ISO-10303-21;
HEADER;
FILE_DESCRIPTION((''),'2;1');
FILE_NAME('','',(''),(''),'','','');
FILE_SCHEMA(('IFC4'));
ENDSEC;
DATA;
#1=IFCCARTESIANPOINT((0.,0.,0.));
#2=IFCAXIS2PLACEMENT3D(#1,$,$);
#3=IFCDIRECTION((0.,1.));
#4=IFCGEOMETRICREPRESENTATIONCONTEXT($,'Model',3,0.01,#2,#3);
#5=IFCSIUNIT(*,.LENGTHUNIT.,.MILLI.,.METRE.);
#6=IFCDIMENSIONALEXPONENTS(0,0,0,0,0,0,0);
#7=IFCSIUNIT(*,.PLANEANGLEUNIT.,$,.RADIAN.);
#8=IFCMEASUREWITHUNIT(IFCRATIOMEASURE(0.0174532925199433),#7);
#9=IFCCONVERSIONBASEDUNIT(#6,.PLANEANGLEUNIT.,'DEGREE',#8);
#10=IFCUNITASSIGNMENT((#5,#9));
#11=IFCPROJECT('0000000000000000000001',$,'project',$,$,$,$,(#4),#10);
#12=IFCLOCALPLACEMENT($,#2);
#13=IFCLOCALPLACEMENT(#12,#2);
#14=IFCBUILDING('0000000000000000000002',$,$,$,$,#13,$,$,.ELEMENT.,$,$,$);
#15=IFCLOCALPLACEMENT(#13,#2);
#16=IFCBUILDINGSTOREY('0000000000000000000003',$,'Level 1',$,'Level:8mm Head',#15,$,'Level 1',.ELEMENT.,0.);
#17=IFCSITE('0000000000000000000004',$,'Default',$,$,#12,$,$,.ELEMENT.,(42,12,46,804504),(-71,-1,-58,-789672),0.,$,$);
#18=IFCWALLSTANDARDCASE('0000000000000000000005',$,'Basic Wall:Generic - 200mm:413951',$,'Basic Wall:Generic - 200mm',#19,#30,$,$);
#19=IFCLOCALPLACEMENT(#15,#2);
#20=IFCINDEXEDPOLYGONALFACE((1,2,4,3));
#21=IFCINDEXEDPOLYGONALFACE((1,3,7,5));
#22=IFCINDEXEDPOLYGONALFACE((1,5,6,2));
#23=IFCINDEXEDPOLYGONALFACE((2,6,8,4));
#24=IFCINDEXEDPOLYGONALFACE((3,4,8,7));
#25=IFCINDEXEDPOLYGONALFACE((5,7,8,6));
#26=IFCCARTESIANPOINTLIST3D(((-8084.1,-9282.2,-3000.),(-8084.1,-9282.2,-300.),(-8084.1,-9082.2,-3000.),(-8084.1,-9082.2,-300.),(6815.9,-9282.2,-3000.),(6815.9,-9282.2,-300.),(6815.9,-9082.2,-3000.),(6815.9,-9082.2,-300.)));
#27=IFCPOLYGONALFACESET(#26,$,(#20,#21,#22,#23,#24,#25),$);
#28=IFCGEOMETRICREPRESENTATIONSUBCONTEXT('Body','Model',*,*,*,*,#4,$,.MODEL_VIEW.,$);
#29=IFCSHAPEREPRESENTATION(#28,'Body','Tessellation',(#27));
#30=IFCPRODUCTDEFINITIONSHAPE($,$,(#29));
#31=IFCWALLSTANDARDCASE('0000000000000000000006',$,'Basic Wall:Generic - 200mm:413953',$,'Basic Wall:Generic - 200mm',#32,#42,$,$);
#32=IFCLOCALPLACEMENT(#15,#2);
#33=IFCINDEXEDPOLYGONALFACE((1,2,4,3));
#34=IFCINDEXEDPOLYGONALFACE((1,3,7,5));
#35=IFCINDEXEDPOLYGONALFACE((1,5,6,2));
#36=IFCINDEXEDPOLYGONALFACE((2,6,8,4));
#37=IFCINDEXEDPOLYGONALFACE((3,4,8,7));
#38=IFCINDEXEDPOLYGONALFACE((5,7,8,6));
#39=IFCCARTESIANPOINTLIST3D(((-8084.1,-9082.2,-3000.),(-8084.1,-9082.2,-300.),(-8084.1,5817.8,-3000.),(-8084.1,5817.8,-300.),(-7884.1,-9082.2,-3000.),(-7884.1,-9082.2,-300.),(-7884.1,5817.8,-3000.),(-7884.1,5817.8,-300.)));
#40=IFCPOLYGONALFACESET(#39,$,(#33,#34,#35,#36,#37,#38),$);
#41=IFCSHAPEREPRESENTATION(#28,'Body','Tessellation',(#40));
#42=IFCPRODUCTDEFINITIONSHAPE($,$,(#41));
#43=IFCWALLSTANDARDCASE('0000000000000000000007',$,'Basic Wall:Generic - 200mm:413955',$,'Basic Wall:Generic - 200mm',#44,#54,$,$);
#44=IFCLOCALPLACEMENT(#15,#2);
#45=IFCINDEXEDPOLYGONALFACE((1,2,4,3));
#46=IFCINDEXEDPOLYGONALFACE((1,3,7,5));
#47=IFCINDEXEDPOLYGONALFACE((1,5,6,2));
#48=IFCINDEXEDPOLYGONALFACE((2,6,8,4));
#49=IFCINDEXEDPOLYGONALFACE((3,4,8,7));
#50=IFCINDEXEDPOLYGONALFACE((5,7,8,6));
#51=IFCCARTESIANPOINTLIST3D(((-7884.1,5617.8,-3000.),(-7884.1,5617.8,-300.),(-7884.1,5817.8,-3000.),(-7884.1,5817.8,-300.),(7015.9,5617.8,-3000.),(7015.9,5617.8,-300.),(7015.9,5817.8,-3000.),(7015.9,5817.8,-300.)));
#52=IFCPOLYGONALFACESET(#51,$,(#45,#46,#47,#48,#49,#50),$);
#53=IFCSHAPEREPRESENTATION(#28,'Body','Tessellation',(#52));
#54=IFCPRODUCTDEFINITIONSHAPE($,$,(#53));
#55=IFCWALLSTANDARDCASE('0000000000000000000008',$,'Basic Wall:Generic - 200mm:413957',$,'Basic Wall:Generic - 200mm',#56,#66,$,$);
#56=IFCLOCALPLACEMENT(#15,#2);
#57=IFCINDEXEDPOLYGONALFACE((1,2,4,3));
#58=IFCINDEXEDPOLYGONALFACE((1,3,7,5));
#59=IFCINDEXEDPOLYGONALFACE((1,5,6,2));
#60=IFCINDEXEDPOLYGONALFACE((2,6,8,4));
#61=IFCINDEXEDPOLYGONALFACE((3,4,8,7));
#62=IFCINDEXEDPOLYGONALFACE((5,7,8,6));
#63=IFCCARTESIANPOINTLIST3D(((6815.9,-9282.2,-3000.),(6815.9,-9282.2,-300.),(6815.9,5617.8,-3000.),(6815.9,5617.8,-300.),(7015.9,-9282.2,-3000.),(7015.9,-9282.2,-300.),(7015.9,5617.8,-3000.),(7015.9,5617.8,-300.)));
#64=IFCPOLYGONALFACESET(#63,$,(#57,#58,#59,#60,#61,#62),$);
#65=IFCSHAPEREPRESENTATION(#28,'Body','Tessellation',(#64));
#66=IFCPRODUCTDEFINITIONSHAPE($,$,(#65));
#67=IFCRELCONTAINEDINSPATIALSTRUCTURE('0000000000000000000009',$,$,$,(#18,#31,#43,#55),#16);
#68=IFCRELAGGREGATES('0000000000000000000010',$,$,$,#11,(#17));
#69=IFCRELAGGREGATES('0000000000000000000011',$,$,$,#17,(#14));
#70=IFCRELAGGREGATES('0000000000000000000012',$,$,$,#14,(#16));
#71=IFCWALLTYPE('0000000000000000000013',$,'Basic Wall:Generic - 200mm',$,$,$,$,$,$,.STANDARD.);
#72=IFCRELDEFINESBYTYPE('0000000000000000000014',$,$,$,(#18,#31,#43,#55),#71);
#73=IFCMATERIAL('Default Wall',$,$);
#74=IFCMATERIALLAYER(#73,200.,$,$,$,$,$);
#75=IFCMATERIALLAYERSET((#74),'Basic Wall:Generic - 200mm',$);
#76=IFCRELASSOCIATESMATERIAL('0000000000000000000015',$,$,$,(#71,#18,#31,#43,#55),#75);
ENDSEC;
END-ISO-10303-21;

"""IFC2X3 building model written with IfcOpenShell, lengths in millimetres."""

from ifc_helpers import new_model, entity, si_unit, converted_unit, direction, frame, frame_2d, origin, place, context, subcontext, project, spatial, polyline, rectangle, extrude, clip, bounded_halfspace, material, layer, layer_set, layer_usage, type_object, element, save


model = new_model("IFC2X3")

# Units and contexts
model_context = context("Model", 3, precision=0.01, world=origin(), true_north=direction((0.0, 1.0)))
body_context = subcontext(model_context, "Body", "Model", "MODEL_VIEW")
ifc_project = project(units=[si_unit("LENGTHUNIT", "METRE", prefix="MILLI"), converted_unit("PLANEANGLEUNIT", "DEGREE", entity("IfcRatioMeasure", 0.0174532925199433), si_unit("PLANEANGLEUNIT", "RADIAN"), dimensions=[0, 0, 0, 0, 0, 0, 0])], contexts=[model_context])

# Site, building, storey
site_placement = place(None, origin())
site = spatial("IfcSite", under=ifc_project, at=site_placement, Name="Default", CompositionType="ELEMENT", RefLatitude=(42, 12, 46, 804504), RefLongitude=(-71, -1, -58, -789672), RefElevation=0.0)
building_placement = place(site_placement, origin())
building = spatial("IfcBuilding", under=site, at=building_placement, CompositionType="ELEMENT")
storey_placement = place(building_placement, origin())
storey = spatial("IfcBuildingStorey", under=building, at=storey_placement, Name="Level 1", ObjectType="Level:8mm Head", LongName="Level 1", CompositionType="ELEMENT", Elevation=0.0)

# Walls
ifc_material = material(Name="Default Wall")
ifc_layer = layer(ifc_material, 200.0)
ifc_layer_set = layer_set([ifc_layer], Name="Basic Wall:Generic - 200mm")
ifc_layer_usage_1 = layer_usage(ifc_layer_set, "AXIS2", "NEGATIVE", 100.0)
wall_type = type_object("IfcWallType", Name="Basic Wall:Generic - 200mm", PredefinedType="STANDARD", material=ifc_layer_set)
wall_1_placement = place(storey_placement, frame((-8084.1, -9182.2, -3000.0)))
element("IfcWallStandardCase", 1, at=wall_1_placement, inside=storey, type_object=wall_type, material=ifc_layer_usage_1, Name="Basic Wall:Generic - 200mm:413951", ObjectType="Basic Wall:Generic - 200mm", context=body_context, shape_type="Clipping", body=[
    clip(extrude(rectangle(XDim=14900.0, YDim=200.0, at=frame_2d((7450.0, 0.0), x_axis=(-1.0, 0.0))), origin(), (0.0, 0.0, 1.0), 2700.0), bounded_halfspace(frame((0.0, -100.0, 2700.0), z_axis=(0.0, 0.0, -1.0), x_axis=(0.0, 1.0, 0.0)), True, frame((0.0, -100.0, 2700.0)), polyline([(0.0, 0.0), (14900.0, 0.0), (14900.0, 200.0), (200.0, 200.0), (0.0, 200.0), (0.0, 0.0)]))),
])
ifc_layer_usage_2 = layer_usage(ifc_layer_set, "AXIS2", "NEGATIVE", 100.0)
wall_2_placement = place(storey_placement, frame((-7984.1, 5817.8, -3000.0), z_axis=(0.0, 0.0, 1.0), x_axis=(0.0, -1.0, 0.0)))
element("IfcWallStandardCase", 2, at=wall_2_placement, inside=storey, type_object=wall_type, material=ifc_layer_usage_2, Name="Basic Wall:Generic - 200mm:413953", ObjectType="Basic Wall:Generic - 200mm", context=body_context, shape_type="Clipping", body=[
    clip(extrude(rectangle(XDim=14900.0, YDim=200.0, at=frame_2d((7450.0, 0.0), x_axis=(-1.0, 0.0))), origin(), (0.0, 0.0, 1.0), 2700.0), bounded_halfspace(frame((0.0, -100.0, 2700.0), z_axis=(0.0, 0.0, -1.0), x_axis=(-1.0, 0.0, 0.0)), True, frame((0.0, -100.0, 2700.0)), polyline([(0.0, 0.0), (14900.0, 0.0), (14900.0, 200.0), (200.0, 200.0), (0.0, 200.0), (0.0, 0.0)]))),
])
ifc_layer_usage_3 = layer_usage(ifc_layer_set, "AXIS2", "NEGATIVE", 100.0)
wall_3_placement = place(storey_placement, frame((7015.9, 5717.8, -3000.0), z_axis=(0.0, 0.0, 1.0), x_axis=(-1.0, 0.0, 0.0)))
element("IfcWallStandardCase", 3, at=wall_3_placement, inside=storey, type_object=wall_type, material=ifc_layer_usage_3, Name="Basic Wall:Generic - 200mm:413955", ObjectType="Basic Wall:Generic - 200mm", context=body_context, shape_type="Clipping", body=[
    clip(extrude(rectangle(XDim=14900.0, YDim=200.0, at=frame_2d((7450.0, 0.0), x_axis=(-1.0, 0.0))), origin(), (0.0, 0.0, 1.0), 2700.0), bounded_halfspace(frame((0.0, -100.0, 2700.0), z_axis=(0.0, 0.0, -1.0), x_axis=(0.0, -1.0, 0.0)), True, frame((0.0, -100.0, 2700.0)), polyline([(0.0, 0.0), (14900.0, 0.0), (14900.0, 200.0), (200.0, 200.0), (0.0, 200.0), (0.0, 0.0)]))),
])
ifc_layer_usage_4 = layer_usage(ifc_layer_set, "AXIS2", "NEGATIVE", 100.0)
wall_4_placement = place(storey_placement, frame((6915.9, -9282.2, -3000.0), z_axis=(0.0, 0.0, 1.0), x_axis=(0.0, 1.0, 0.0)))
element("IfcWallStandardCase", 4, at=wall_4_placement, inside=storey, type_object=wall_type, material=ifc_layer_usage_4, Name="Basic Wall:Generic - 200mm:413957", ObjectType="Basic Wall:Generic - 200mm", context=body_context, shape_type="Clipping", body=[
    clip(extrude(rectangle(XDim=14900.0, YDim=200.0, at=frame_2d((7450.0, 0.0), x_axis=(-1.0, 0.0))), origin(), (0.0, 0.0, 1.0), 2700.0), bounded_halfspace(frame((0.0, -100.0, 2700.0), z_axis=(0.0, 0.0, -1.0), x_axis=(1.0, 0.0, 0.0)), True, frame((0.0, -100.0, 2700.0)), polyline([(0.0, 0.0), (14900.0, 0.0), (14900.0, 200.0), (200.0, 200.0), (0.0, 200.0), (0.0, 0.0)]))),
])

save(model, "model.ifc")
